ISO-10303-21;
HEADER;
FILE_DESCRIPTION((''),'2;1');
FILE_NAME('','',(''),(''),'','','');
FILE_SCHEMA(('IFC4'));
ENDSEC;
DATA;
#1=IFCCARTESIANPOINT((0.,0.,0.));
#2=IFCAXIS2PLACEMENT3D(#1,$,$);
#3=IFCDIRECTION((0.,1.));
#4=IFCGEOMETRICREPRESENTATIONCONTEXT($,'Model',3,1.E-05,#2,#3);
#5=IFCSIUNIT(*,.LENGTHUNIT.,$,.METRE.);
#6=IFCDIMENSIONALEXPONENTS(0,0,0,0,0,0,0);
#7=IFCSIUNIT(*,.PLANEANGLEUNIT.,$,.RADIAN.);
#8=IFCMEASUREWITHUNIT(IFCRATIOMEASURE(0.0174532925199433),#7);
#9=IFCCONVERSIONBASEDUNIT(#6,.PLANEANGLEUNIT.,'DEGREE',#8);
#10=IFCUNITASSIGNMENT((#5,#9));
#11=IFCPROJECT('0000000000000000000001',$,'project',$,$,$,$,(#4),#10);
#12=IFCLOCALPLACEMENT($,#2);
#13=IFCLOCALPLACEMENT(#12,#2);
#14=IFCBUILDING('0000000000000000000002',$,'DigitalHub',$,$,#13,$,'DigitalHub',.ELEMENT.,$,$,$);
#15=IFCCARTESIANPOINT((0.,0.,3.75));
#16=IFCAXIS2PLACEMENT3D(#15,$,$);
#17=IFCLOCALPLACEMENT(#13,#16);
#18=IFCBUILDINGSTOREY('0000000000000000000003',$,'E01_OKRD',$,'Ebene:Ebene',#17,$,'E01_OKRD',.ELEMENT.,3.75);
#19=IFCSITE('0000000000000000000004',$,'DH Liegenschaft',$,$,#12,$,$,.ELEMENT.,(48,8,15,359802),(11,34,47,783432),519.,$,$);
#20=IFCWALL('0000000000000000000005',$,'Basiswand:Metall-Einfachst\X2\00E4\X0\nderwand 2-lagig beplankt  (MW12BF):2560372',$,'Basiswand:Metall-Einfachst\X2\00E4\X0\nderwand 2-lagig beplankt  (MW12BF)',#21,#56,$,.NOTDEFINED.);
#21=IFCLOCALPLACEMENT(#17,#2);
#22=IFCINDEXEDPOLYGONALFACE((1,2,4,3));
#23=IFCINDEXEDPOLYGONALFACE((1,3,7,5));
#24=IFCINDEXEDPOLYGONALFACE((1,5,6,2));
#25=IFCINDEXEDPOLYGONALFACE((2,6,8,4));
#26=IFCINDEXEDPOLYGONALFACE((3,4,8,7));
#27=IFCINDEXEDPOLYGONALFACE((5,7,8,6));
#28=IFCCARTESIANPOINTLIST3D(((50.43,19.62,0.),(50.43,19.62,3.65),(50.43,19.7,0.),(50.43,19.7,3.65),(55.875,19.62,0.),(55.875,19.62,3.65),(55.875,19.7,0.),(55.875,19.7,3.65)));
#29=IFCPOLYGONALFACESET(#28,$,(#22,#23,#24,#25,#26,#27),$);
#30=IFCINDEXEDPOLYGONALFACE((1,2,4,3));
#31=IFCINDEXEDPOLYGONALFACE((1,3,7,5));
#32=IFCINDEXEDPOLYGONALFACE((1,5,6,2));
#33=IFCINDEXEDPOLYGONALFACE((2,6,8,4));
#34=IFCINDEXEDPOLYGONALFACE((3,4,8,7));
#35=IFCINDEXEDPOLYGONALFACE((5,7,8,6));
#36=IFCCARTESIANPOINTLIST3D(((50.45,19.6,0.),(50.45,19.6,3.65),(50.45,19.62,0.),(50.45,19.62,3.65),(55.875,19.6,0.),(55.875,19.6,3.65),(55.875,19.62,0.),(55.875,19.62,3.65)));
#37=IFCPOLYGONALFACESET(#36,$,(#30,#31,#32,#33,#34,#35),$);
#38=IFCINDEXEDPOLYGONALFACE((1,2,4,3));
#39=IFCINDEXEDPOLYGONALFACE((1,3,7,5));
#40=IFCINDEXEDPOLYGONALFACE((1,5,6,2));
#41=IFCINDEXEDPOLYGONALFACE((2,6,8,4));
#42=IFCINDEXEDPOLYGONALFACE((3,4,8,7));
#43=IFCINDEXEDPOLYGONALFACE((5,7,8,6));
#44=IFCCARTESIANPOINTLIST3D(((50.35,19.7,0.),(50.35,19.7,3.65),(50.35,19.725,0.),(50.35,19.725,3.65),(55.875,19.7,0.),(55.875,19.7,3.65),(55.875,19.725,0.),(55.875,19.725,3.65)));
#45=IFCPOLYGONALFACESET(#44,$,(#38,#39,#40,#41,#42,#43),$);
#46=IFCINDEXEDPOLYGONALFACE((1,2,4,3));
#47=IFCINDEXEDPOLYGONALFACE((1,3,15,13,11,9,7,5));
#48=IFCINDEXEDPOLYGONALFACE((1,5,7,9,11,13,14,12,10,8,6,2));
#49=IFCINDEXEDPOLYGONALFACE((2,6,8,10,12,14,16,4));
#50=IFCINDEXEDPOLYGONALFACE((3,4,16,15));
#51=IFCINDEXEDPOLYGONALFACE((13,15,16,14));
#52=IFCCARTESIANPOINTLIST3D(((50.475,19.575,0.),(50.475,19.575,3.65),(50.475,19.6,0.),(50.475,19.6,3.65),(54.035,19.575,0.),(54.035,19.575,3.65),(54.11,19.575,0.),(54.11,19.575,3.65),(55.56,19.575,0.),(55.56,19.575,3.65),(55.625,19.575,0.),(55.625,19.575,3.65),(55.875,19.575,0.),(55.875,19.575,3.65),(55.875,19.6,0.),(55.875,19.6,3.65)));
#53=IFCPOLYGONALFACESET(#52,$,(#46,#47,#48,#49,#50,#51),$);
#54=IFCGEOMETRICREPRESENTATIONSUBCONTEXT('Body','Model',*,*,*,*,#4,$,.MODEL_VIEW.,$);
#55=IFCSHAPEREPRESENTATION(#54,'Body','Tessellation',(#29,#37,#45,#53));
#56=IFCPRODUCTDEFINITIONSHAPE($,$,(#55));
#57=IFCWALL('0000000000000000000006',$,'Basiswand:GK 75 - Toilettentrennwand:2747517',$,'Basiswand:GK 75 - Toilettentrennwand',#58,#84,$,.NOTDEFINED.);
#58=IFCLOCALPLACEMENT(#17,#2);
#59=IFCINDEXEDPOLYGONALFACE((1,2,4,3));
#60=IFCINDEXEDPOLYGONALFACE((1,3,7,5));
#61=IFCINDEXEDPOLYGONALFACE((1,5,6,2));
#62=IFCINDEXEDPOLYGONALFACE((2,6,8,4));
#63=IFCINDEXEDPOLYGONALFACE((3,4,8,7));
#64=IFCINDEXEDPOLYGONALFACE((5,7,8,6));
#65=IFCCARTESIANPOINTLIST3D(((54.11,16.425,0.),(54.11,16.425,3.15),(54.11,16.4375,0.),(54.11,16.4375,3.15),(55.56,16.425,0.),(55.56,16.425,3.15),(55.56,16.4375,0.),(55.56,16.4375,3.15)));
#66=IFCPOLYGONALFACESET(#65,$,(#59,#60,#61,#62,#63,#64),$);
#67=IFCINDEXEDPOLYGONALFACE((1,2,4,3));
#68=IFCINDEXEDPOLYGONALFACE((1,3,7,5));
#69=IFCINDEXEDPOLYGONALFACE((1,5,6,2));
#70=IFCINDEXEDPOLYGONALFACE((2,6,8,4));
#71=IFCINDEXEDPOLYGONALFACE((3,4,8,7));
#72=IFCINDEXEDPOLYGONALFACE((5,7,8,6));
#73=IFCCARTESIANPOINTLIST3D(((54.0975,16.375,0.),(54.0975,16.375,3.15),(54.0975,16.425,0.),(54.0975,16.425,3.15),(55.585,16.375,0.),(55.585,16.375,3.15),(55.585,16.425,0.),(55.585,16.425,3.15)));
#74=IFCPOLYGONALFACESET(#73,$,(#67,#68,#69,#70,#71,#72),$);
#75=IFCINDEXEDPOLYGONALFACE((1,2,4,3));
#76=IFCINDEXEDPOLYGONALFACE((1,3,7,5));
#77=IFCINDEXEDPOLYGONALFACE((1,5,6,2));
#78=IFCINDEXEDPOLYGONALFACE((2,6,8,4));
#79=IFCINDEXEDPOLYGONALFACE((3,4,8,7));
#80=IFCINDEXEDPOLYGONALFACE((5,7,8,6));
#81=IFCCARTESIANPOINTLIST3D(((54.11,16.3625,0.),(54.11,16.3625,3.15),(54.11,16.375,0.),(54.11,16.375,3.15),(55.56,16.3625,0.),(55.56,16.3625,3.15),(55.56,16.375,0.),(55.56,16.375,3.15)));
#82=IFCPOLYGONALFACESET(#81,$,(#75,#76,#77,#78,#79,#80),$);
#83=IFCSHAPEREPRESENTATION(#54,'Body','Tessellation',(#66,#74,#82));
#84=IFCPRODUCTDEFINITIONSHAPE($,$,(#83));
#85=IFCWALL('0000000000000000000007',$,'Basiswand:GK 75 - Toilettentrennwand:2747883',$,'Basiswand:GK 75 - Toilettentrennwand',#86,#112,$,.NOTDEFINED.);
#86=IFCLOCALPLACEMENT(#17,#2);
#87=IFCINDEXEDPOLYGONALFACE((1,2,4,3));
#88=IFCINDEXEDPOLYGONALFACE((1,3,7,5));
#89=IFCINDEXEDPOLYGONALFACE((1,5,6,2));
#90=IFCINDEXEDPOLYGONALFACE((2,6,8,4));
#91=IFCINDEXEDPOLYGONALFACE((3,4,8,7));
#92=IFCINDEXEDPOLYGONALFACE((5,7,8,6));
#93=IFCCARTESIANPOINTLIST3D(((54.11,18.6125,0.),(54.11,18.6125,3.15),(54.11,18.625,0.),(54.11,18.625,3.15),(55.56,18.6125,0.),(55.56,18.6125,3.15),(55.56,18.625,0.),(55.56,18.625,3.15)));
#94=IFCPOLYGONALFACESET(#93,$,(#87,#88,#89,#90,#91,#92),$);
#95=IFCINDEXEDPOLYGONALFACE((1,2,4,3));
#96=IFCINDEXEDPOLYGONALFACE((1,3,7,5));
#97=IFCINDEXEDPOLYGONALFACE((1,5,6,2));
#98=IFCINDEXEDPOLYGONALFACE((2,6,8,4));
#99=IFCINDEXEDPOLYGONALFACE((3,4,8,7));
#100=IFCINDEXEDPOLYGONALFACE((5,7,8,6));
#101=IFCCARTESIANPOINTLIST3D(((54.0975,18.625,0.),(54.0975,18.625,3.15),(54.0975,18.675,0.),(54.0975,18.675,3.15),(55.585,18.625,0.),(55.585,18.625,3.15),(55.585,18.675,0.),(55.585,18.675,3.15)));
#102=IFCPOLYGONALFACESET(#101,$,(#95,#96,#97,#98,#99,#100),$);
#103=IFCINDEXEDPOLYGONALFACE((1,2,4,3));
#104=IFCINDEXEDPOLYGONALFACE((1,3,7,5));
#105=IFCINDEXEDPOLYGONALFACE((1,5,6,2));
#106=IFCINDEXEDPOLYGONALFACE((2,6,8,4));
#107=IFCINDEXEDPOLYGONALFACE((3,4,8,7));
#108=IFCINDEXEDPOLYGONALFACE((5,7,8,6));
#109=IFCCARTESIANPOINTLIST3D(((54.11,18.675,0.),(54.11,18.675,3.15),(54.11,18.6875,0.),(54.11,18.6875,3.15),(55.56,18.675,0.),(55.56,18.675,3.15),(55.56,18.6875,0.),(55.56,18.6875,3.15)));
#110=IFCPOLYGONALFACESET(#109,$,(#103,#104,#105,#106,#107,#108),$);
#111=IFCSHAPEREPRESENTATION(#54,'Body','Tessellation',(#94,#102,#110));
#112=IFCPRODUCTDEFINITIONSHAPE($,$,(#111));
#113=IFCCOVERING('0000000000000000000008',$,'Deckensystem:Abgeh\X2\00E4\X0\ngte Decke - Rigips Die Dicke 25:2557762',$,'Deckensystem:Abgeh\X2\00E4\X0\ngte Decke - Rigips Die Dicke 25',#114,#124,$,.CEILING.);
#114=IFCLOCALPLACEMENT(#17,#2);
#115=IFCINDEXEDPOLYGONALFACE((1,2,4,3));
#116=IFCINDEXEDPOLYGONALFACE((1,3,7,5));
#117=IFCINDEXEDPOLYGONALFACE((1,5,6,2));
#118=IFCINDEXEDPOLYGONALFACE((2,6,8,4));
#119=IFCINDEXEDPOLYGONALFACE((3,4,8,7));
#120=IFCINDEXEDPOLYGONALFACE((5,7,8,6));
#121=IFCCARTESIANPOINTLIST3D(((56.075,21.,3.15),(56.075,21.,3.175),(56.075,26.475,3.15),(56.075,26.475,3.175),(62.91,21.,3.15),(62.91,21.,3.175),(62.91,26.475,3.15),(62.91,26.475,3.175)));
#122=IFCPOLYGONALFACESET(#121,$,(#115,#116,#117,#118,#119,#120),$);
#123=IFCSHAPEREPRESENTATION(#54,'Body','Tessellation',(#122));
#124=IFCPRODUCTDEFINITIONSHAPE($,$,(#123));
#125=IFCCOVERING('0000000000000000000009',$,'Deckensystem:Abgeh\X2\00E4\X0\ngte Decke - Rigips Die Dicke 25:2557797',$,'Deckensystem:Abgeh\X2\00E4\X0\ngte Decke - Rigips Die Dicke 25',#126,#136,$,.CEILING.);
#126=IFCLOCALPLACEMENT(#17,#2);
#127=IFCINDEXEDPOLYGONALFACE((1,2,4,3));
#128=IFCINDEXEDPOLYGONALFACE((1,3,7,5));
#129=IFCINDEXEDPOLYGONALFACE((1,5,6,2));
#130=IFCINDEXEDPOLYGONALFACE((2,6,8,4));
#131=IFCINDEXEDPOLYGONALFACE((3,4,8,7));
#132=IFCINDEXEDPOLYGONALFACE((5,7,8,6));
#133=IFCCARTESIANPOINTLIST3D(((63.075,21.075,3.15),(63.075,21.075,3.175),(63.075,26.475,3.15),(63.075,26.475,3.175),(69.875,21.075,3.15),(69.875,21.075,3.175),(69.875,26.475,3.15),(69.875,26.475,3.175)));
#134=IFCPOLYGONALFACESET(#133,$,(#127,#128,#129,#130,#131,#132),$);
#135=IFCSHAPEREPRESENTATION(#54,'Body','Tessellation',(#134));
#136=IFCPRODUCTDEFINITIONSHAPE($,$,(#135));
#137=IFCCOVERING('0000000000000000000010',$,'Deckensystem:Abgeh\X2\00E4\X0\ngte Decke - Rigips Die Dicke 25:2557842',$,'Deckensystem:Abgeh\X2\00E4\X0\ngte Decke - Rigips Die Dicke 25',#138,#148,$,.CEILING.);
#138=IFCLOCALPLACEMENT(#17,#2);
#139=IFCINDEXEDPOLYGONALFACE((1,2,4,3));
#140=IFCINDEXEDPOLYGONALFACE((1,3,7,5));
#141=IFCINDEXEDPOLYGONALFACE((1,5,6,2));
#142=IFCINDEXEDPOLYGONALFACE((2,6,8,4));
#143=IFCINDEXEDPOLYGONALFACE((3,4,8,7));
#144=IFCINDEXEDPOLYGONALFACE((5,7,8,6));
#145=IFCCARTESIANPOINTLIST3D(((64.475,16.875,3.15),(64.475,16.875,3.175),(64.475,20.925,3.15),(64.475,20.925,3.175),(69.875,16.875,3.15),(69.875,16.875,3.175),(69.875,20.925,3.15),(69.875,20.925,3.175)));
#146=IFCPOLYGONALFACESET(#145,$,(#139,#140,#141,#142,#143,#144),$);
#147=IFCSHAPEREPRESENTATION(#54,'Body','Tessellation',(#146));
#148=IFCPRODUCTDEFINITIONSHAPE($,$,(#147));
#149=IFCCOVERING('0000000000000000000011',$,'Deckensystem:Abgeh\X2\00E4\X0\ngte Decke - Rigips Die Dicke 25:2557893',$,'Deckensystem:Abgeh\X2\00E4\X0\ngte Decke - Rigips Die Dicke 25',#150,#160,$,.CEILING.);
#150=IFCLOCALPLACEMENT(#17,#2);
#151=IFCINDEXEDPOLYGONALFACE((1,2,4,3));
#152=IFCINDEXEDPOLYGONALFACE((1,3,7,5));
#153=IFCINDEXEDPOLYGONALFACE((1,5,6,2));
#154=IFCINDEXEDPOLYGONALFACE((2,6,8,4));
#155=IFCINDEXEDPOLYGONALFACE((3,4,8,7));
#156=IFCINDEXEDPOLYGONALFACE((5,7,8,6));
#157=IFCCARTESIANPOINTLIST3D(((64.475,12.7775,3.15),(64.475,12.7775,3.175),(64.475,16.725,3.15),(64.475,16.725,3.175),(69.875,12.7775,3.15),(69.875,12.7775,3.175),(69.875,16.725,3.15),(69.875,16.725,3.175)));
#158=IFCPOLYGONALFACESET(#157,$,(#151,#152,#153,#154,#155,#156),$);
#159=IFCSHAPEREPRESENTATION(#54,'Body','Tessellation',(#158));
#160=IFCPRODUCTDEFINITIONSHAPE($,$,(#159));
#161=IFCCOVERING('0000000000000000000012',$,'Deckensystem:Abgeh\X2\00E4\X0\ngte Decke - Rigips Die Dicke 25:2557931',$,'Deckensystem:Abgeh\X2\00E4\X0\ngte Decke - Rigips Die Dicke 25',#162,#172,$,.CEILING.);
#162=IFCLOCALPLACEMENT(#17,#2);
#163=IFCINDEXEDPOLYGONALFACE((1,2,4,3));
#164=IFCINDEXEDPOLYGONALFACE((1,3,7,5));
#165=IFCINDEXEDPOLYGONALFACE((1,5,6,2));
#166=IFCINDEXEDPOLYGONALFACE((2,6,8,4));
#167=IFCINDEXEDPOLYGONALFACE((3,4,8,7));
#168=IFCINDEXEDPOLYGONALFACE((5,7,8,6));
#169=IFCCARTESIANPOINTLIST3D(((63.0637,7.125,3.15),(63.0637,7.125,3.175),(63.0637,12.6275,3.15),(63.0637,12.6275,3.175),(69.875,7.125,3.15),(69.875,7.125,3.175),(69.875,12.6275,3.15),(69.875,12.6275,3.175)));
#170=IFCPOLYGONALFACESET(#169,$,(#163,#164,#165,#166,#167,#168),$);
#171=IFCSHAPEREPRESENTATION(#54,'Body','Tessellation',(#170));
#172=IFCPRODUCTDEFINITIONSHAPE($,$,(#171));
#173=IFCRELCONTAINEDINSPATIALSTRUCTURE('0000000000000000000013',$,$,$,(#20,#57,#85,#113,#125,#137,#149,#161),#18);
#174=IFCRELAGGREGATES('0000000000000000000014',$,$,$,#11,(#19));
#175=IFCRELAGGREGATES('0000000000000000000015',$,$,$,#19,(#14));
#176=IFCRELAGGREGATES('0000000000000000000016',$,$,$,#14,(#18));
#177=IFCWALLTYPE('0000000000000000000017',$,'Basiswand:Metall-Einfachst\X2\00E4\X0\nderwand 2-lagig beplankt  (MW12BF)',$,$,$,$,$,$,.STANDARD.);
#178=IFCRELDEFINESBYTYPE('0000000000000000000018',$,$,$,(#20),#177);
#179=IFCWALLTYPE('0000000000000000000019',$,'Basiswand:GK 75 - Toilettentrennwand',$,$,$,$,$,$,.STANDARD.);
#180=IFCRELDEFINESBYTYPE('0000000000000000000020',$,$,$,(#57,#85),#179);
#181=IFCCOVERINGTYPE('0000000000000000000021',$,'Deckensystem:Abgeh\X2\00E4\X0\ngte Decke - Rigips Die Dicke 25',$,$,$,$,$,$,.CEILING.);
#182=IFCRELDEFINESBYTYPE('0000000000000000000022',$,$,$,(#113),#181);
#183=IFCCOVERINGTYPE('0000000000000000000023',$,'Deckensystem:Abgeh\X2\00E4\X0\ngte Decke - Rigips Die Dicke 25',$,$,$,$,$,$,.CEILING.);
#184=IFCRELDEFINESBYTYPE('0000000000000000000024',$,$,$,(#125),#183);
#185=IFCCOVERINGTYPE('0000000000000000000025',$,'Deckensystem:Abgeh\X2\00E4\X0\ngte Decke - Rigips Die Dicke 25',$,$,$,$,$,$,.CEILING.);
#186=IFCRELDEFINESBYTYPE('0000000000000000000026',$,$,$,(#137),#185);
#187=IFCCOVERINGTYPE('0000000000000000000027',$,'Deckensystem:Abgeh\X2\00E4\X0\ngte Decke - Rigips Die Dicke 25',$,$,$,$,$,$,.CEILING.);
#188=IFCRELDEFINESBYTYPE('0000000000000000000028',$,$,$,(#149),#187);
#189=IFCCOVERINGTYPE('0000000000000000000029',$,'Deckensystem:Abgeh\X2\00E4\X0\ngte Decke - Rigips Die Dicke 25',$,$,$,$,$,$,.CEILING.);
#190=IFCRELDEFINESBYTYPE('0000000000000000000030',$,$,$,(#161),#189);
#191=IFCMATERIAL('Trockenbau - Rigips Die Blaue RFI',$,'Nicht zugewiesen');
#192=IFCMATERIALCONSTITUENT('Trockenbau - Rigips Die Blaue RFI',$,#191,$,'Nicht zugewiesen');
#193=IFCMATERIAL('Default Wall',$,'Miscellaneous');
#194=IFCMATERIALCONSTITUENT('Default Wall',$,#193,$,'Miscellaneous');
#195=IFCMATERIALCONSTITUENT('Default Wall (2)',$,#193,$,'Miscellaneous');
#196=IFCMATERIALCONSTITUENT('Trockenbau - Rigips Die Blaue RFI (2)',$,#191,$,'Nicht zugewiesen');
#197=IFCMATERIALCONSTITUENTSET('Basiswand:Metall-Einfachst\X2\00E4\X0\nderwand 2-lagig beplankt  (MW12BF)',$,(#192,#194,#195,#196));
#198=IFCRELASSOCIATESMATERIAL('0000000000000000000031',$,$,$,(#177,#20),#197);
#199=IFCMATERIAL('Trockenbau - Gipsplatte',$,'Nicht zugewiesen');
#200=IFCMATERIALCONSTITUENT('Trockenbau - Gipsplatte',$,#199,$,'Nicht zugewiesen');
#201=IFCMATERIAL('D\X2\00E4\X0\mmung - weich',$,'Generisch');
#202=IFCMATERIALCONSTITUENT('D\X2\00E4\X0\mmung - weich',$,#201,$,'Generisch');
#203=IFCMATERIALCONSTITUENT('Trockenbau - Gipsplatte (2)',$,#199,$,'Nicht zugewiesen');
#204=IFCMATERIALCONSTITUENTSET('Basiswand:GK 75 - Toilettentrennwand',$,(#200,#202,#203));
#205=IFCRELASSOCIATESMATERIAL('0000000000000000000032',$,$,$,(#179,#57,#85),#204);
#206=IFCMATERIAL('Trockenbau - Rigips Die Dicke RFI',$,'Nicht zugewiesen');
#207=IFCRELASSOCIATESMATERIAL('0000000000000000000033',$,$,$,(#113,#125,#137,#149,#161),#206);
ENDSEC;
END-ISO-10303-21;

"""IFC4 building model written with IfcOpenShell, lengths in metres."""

from ifc_helpers import new_model, entity, si_unit, converted_unit, direction, frame, origin, place, context, subcontext, project, spatial, indexed_curve, outline, extrude, material, constituent, constituent_set, type_object, element, save


model = new_model("IFC4")

# Units and contexts
model_context = context("Model", 3, precision=1e-05, world=origin(), true_north=direction((0.0, 1.0)))
body_context = subcontext(model_context, "Body", "Model", "MODEL_VIEW")
ifc_project = project(units=[si_unit("LENGTHUNIT", "METRE"), converted_unit("PLANEANGLEUNIT", "DEGREE", entity("IfcRatioMeasure", 0.0174532925199433), si_unit("PLANEANGLEUNIT", "RADIAN"), dimensions=[0, 0, 0, 0, 0, 0, 0])], contexts=[model_context])

# Site, building, storey
site_placement = place(None, frame((0.0, 0.0, 0.0)))
site = spatial("IfcSite", under=ifc_project, at=site_placement, Name="DH Liegenschaft", CompositionType="ELEMENT", RefLatitude=(48, 8, 15, 359802), RefLongitude=(11, 34, 47, 783432), RefElevation=519.0)
building_placement = place(site_placement, origin())
building = spatial("IfcBuilding", under=site, at=building_placement, Name="DigitalHub", LongName="DigitalHub", CompositionType="ELEMENT")
storey_placement = place(building_placement, frame((0.0, 0.0, 3.75)))
storey = spatial("IfcBuildingStorey", under=building, at=storey_placement, Name="E01_OKRD", ObjectType="Ebene:Ebene", LongName="E01_OKRD", CompositionType="ELEMENT", Elevation=3.75)

# Shared definitions
ifc_material_1 = material(Name="Trockenbau - Rigips Die Blaue RFI", Category="Nicht zugewiesen")
ifc_constituent_1 = constituent(ifc_material_1, Name="Trockenbau - Rigips Die Blaue RFI", Category="Nicht zugewiesen")
ifc_material_2 = material(Name="Default Wall", Category="Miscellaneous")
ifc_constituent_2 = constituent(ifc_material_2, Name="Default Wall", Category="Miscellaneous")
ifc_constituent_3 = constituent(ifc_material_2, Name="Default Wall (2)", Category="Miscellaneous")
ifc_constituent_4 = constituent(ifc_material_1, Name="Trockenbau - Rigips Die Blaue RFI (2)", Category="Nicht zugewiesen")
ifc_constituent_set_1 = constituent_set(constituents=[ifc_constituent_1, ifc_constituent_2, ifc_constituent_3, ifc_constituent_4], Name="Basiswand:Metall-Einfachständerwand 2-lagig beplankt  (MW12BF)")
wall_type_1 = type_object("IfcWallType", Name="Basiswand:Metall-Einfachständerwand 2-lagig beplankt  (MW12BF)", PredefinedType="STANDARD", material=ifc_constituent_set_1)

# Walls
wall_1_placement = place(storey_placement, frame((55.875, 19.65, 0.0), z_axis=(0.0, 0.0, 1.0), x_axis=(-1.0, 0.0, 0.0)))
element("IfcWall", 1, at=wall_1_placement, inside=storey, type_object=wall_type_1, material=ifc_constituent_set_1, Name="Basiswand:Metall-Einfachständerwand 2-lagig beplankt  (MW12BF):2560372", ObjectType="Basiswand:Metall-Einfachständerwand 2-lagig beplankt  (MW12BF)", PredefinedType="NOTDEFINED", context=body_context, shape_type="SweptSolid", body=[
    extrude(outline(indexed_curve([(-2.7225, -0.04), (2.7225, -0.04), (2.7225, 0.04), (-2.7225, 0.04), (-2.7225, -0.04)], self_intersect=False)), frame((2.7225, -0.01, 0.0)), (0.0, 0.0, 1.0), 3.65),
    extrude(outline(indexed_curve([(-2.7125, -0.01), (2.7125, -0.01), (2.7125, 0.01), (-2.7125, 0.01), (-2.7125, -0.01)], self_intersect=False)), frame((2.7125, 0.04, 0.0)), (0.0, 0.0, 1.0), 3.65),
    extrude(outline(indexed_curve([(-0.0125, -2.7625), (0.0125, -2.7625), (0.0125, 2.7625), (-0.0125, 2.7625), (-0.0125, -2.7625)], self_intersect=False)), frame((2.7625, -0.0625, 0.0), z_axis=(0.0, 0.0, 1.0), x_axis=(0.0, 1.0, 0.0)), (0.0, 0.0, 1.0), 3.65),
    extrude(outline(indexed_curve([(0.0313, -0.0063), (0.1063, -0.0063), (1.5563, -0.0063), (1.6213, -0.0063), (1.8712, -0.0063), (1.8712, 0.0187), (-3.5288, 0.0188), (-3.5288, -0.0062), (0.0313, -0.0063)], self_intersect=False)), frame((1.8713, 0.0687, 0.0), z_axis=(0.0, 0.0, 1.0), x_axis=(-1.0, 0.0, 0.0)), (0.0, 0.0, 1.0), 3.65),
])
ifc_material_3 = material(Name="Trockenbau - Gipsplatte", Category="Nicht zugewiesen")
ifc_material_4 = material(Name="Dämmung - weich", Category="Generisch")
ifc_constituent_5 = constituent(ifc_material_3, Name="Trockenbau - Gipsplatte", Category="Nicht zugewiesen")
ifc_constituent_6 = constituent(ifc_material_4, Name="Dämmung - weich", Category="Generisch")
ifc_constituent_7 = constituent(ifc_material_3, Name="Trockenbau - Gipsplatte (2)", Category="Nicht zugewiesen")
ifc_constituent_set_2 = constituent_set(constituents=[ifc_constituent_5, ifc_constituent_6, ifc_constituent_7], Name="Basiswand:GK 75 - Toilettentrennwand")
wall_type_2 = type_object("IfcWallType", Name="Basiswand:GK 75 - Toilettentrennwand", PredefinedType="STANDARD", material=ifc_constituent_set_2)
wall_2_placement = place(storey_placement, frame((55.56, 16.4, 0.0), z_axis=(0.0, 0.0, 1.0), x_axis=(-1.0, 0.0, 0.0)))
element("IfcWall", 2, at=wall_2_placement, inside=storey, type_object=wall_type_2, material=ifc_constituent_set_2, Name="Basiswand:GK 75 - Toilettentrennwand:2747517", ObjectType="Basiswand:GK 75 - Toilettentrennwand", PredefinedType="NOTDEFINED", context=body_context, shape_type="SweptSolid", body=[
    extrude(outline(indexed_curve([(-0.0063, -0.725), (0.0062, -0.725), (0.0063, 0.725), (-0.0062, 0.725), (-0.0063, -0.725)], self_intersect=False)), frame((0.725, -0.0312, 0.0), z_axis=(0.0, 0.0, 1.0), x_axis=(0.0, 1.0, 0.0)), (0.0, 0.0, 1.0), 3.15),
    extrude(outline(indexed_curve([(-0.7437, -0.025), (0.7437, -0.025), (0.7437, 0.025), (-0.7437, 0.025), (-0.7437, -0.025)], self_intersect=False)), frame((0.7187, 0.0, 0.0)), (0.0, 0.0, 1.0), 3.15),
    extrude(outline(indexed_curve([(-0.0063, -0.725), (0.0062, -0.725), (0.0063, 0.725), (-0.0062, 0.725), (-0.0063, -0.725)], self_intersect=False)), frame((0.725, 0.0312, 0.0), z_axis=(0.0, 0.0, 1.0), x_axis=(0.0, -1.0, 0.0)), (0.0, 0.0, 1.0), 3.15),
])
wall_3_placement = place(storey_placement, frame((54.11, 18.65, 0.0)))
element("IfcWall", 3, at=wall_3_placement, inside=storey, type_object=wall_type_2, material=ifc_constituent_set_2, Name="Basiswand:GK 75 - Toilettentrennwand:2747883", ObjectType="Basiswand:GK 75 - Toilettentrennwand", PredefinedType="NOTDEFINED", context=body_context, shape_type="SweptSolid", body=[
    extrude(outline(indexed_curve([(-0.0063, -0.725), (0.0062, -0.725), (0.0063, 0.725), (-0.0062, 0.725), (-0.0063, -0.725)], self_intersect=False)), frame((0.725, -0.0312, 0.0), z_axis=(0.0, 0.0, 1.0), x_axis=(0.0, 1.0, 0.0)), (0.0, 0.0, 1.0), 3.15),
    extrude(outline(indexed_curve([(-0.7437, -0.025), (0.7437, -0.025), (0.7437, 0.025), (-0.7437, 0.025), (-0.7437, -0.025)], self_intersect=False)), frame((0.7312, 0.0, 0.0)), (0.0, 0.0, 1.0), 3.15),
    extrude(outline(indexed_curve([(-0.0063, -0.725), (0.0062, -0.725), (0.0063, 0.725), (-0.0062, 0.725), (-0.0063, -0.725)], self_intersect=False)), frame((0.725, 0.0312, 0.0), z_axis=(0.0, 0.0, 1.0), x_axis=(0.0, -1.0, 0.0)), (0.0, 0.0, 1.0), 3.15),
])

# Coverings
ifc_material_5 = material(Name="Trockenbau - Rigips Die Dicke RFI", Category="Nicht zugewiesen")
covering_type_1 = type_object("IfcCoveringType", Name="Deckensystem:Abgehängte Decke - Rigips Die Dicke 25", PredefinedType="CEILING")
covering_1_placement = place(storey_placement, frame((56.075, 21.0, 3.15)))
element("IfcCovering", 4, at=covering_1_placement, inside=storey, type_object=covering_type_1, material=ifc_material_5, Name="Deckensystem:Abgehängte Decke - Rigips Die Dicke 25:2557762", ObjectType="Deckensystem:Abgehängte Decke - Rigips Die Dicke 25", PredefinedType="CEILING", context=body_context, shape_type="SweptSolid", body=[
    extrude(outline(indexed_curve([(-3.4175, -2.7375), (3.4175, -2.7375), (3.4175, 2.7375), (-3.4175, 2.7375), (-3.4175, -2.7375)], self_intersect=False)), frame((3.4175, 2.7375, 0.0), z_axis=(0.0, 0.0, 1.0), x_axis=(-1.0, 0.0, 0.0)), (0.0, 0.0, 1.0), 0.025),
])
covering_type_2 = type_object("IfcCoveringType", Name="Deckensystem:Abgehängte Decke - Rigips Die Dicke 25", PredefinedType="CEILING")
covering_2_placement = place(storey_placement, frame((63.075, 21.075, 3.15)))
element("IfcCovering", 5, at=covering_2_placement, inside=storey, type_object=covering_type_2, material=ifc_material_5, Name="Deckensystem:Abgehängte Decke - Rigips Die Dicke 25:2557797", ObjectType="Deckensystem:Abgehängte Decke - Rigips Die Dicke 25", PredefinedType="CEILING", context=body_context, shape_type="SweptSolid", body=[
    extrude(outline(indexed_curve([(-3.4, -2.7), (3.4, -2.7), (3.4, 2.7), (-3.4, 2.7), (-3.4, -2.7)], self_intersect=False)), frame((3.4, 2.7, 0.0), z_axis=(0.0, 0.0, 1.0), x_axis=(-1.0, 0.0, 0.0)), (0.0, 0.0, 1.0), 0.025),
])
covering_type_3 = type_object("IfcCoveringType", Name="Deckensystem:Abgehängte Decke - Rigips Die Dicke 25", PredefinedType="CEILING")
covering_3_placement = place(storey_placement, frame((64.475, 16.875, 3.15)))
element("IfcCovering", 6, at=covering_3_placement, inside=storey, type_object=covering_type_3, material=ifc_material_5, Name="Deckensystem:Abgehängte Decke - Rigips Die Dicke 25:2557842", ObjectType="Deckensystem:Abgehängte Decke - Rigips Die Dicke 25", PredefinedType="CEILING", context=body_context, shape_type="SweptSolid", body=[
    extrude(outline(indexed_curve([(-2.7, -2.025), (2.7, -2.025), (2.7, 2.025), (-2.7, 2.025), (-2.7, -2.025)], self_intersect=False)), frame((2.7, 2.025, 0.0), z_axis=(0.0, 0.0, 1.0), x_axis=(-1.0, 0.0, 0.0)), (0.0, 0.0, 1.0), 0.025),
])
covering_type_4 = type_object("IfcCoveringType", Name="Deckensystem:Abgehängte Decke - Rigips Die Dicke 25", PredefinedType="CEILING")
covering_4_placement = place(storey_placement, frame((64.475, 12.7775, 3.15)))
element("IfcCovering", 7, at=covering_4_placement, inside=storey, type_object=covering_type_4, material=ifc_material_5, Name="Deckensystem:Abgehängte Decke - Rigips Die Dicke 25:2557893", ObjectType="Deckensystem:Abgehängte Decke - Rigips Die Dicke 25", PredefinedType="CEILING", context=body_context, shape_type="SweptSolid", body=[
    extrude(outline(indexed_curve([(-2.7, -1.9737), (2.7, -1.9737), (2.7, 1.9737), (-2.7, 1.9737), (-2.7, -1.9737)], self_intersect=False)), frame((2.7, 1.9737, 0.0), z_axis=(0.0, 0.0, 1.0), x_axis=(-1.0, 0.0, 0.0)), (0.0, 0.0, 1.0), 0.025),
])
covering_type_5 = type_object("IfcCoveringType", Name="Deckensystem:Abgehängte Decke - Rigips Die Dicke 25", PredefinedType="CEILING")
covering_5_placement = place(storey_placement, frame((63.0637, 7.125, 3.15)))
element("IfcCovering", 8, at=covering_5_placement, inside=storey, type_object=covering_type_5, material=ifc_material_5, Name="Deckensystem:Abgehängte Decke - Rigips Die Dicke 25:2557931", ObjectType="Deckensystem:Abgehängte Decke - Rigips Die Dicke 25", PredefinedType="CEILING", context=body_context, shape_type="SweptSolid", body=[
    extrude(outline(indexed_curve([(-3.4056, -2.7512), (3.4056, -2.7512), (3.4056, 2.7512), (-3.4056, 2.7512), (-3.4056, -2.7512)], self_intersect=False)), frame((3.4056, 2.7512, 0.0), z_axis=(0.0, 0.0, 1.0), x_axis=(-1.0, 0.0, 0.0)), (0.0, 0.0, 1.0), 0.025),
])

save(model, "model.ifc")
